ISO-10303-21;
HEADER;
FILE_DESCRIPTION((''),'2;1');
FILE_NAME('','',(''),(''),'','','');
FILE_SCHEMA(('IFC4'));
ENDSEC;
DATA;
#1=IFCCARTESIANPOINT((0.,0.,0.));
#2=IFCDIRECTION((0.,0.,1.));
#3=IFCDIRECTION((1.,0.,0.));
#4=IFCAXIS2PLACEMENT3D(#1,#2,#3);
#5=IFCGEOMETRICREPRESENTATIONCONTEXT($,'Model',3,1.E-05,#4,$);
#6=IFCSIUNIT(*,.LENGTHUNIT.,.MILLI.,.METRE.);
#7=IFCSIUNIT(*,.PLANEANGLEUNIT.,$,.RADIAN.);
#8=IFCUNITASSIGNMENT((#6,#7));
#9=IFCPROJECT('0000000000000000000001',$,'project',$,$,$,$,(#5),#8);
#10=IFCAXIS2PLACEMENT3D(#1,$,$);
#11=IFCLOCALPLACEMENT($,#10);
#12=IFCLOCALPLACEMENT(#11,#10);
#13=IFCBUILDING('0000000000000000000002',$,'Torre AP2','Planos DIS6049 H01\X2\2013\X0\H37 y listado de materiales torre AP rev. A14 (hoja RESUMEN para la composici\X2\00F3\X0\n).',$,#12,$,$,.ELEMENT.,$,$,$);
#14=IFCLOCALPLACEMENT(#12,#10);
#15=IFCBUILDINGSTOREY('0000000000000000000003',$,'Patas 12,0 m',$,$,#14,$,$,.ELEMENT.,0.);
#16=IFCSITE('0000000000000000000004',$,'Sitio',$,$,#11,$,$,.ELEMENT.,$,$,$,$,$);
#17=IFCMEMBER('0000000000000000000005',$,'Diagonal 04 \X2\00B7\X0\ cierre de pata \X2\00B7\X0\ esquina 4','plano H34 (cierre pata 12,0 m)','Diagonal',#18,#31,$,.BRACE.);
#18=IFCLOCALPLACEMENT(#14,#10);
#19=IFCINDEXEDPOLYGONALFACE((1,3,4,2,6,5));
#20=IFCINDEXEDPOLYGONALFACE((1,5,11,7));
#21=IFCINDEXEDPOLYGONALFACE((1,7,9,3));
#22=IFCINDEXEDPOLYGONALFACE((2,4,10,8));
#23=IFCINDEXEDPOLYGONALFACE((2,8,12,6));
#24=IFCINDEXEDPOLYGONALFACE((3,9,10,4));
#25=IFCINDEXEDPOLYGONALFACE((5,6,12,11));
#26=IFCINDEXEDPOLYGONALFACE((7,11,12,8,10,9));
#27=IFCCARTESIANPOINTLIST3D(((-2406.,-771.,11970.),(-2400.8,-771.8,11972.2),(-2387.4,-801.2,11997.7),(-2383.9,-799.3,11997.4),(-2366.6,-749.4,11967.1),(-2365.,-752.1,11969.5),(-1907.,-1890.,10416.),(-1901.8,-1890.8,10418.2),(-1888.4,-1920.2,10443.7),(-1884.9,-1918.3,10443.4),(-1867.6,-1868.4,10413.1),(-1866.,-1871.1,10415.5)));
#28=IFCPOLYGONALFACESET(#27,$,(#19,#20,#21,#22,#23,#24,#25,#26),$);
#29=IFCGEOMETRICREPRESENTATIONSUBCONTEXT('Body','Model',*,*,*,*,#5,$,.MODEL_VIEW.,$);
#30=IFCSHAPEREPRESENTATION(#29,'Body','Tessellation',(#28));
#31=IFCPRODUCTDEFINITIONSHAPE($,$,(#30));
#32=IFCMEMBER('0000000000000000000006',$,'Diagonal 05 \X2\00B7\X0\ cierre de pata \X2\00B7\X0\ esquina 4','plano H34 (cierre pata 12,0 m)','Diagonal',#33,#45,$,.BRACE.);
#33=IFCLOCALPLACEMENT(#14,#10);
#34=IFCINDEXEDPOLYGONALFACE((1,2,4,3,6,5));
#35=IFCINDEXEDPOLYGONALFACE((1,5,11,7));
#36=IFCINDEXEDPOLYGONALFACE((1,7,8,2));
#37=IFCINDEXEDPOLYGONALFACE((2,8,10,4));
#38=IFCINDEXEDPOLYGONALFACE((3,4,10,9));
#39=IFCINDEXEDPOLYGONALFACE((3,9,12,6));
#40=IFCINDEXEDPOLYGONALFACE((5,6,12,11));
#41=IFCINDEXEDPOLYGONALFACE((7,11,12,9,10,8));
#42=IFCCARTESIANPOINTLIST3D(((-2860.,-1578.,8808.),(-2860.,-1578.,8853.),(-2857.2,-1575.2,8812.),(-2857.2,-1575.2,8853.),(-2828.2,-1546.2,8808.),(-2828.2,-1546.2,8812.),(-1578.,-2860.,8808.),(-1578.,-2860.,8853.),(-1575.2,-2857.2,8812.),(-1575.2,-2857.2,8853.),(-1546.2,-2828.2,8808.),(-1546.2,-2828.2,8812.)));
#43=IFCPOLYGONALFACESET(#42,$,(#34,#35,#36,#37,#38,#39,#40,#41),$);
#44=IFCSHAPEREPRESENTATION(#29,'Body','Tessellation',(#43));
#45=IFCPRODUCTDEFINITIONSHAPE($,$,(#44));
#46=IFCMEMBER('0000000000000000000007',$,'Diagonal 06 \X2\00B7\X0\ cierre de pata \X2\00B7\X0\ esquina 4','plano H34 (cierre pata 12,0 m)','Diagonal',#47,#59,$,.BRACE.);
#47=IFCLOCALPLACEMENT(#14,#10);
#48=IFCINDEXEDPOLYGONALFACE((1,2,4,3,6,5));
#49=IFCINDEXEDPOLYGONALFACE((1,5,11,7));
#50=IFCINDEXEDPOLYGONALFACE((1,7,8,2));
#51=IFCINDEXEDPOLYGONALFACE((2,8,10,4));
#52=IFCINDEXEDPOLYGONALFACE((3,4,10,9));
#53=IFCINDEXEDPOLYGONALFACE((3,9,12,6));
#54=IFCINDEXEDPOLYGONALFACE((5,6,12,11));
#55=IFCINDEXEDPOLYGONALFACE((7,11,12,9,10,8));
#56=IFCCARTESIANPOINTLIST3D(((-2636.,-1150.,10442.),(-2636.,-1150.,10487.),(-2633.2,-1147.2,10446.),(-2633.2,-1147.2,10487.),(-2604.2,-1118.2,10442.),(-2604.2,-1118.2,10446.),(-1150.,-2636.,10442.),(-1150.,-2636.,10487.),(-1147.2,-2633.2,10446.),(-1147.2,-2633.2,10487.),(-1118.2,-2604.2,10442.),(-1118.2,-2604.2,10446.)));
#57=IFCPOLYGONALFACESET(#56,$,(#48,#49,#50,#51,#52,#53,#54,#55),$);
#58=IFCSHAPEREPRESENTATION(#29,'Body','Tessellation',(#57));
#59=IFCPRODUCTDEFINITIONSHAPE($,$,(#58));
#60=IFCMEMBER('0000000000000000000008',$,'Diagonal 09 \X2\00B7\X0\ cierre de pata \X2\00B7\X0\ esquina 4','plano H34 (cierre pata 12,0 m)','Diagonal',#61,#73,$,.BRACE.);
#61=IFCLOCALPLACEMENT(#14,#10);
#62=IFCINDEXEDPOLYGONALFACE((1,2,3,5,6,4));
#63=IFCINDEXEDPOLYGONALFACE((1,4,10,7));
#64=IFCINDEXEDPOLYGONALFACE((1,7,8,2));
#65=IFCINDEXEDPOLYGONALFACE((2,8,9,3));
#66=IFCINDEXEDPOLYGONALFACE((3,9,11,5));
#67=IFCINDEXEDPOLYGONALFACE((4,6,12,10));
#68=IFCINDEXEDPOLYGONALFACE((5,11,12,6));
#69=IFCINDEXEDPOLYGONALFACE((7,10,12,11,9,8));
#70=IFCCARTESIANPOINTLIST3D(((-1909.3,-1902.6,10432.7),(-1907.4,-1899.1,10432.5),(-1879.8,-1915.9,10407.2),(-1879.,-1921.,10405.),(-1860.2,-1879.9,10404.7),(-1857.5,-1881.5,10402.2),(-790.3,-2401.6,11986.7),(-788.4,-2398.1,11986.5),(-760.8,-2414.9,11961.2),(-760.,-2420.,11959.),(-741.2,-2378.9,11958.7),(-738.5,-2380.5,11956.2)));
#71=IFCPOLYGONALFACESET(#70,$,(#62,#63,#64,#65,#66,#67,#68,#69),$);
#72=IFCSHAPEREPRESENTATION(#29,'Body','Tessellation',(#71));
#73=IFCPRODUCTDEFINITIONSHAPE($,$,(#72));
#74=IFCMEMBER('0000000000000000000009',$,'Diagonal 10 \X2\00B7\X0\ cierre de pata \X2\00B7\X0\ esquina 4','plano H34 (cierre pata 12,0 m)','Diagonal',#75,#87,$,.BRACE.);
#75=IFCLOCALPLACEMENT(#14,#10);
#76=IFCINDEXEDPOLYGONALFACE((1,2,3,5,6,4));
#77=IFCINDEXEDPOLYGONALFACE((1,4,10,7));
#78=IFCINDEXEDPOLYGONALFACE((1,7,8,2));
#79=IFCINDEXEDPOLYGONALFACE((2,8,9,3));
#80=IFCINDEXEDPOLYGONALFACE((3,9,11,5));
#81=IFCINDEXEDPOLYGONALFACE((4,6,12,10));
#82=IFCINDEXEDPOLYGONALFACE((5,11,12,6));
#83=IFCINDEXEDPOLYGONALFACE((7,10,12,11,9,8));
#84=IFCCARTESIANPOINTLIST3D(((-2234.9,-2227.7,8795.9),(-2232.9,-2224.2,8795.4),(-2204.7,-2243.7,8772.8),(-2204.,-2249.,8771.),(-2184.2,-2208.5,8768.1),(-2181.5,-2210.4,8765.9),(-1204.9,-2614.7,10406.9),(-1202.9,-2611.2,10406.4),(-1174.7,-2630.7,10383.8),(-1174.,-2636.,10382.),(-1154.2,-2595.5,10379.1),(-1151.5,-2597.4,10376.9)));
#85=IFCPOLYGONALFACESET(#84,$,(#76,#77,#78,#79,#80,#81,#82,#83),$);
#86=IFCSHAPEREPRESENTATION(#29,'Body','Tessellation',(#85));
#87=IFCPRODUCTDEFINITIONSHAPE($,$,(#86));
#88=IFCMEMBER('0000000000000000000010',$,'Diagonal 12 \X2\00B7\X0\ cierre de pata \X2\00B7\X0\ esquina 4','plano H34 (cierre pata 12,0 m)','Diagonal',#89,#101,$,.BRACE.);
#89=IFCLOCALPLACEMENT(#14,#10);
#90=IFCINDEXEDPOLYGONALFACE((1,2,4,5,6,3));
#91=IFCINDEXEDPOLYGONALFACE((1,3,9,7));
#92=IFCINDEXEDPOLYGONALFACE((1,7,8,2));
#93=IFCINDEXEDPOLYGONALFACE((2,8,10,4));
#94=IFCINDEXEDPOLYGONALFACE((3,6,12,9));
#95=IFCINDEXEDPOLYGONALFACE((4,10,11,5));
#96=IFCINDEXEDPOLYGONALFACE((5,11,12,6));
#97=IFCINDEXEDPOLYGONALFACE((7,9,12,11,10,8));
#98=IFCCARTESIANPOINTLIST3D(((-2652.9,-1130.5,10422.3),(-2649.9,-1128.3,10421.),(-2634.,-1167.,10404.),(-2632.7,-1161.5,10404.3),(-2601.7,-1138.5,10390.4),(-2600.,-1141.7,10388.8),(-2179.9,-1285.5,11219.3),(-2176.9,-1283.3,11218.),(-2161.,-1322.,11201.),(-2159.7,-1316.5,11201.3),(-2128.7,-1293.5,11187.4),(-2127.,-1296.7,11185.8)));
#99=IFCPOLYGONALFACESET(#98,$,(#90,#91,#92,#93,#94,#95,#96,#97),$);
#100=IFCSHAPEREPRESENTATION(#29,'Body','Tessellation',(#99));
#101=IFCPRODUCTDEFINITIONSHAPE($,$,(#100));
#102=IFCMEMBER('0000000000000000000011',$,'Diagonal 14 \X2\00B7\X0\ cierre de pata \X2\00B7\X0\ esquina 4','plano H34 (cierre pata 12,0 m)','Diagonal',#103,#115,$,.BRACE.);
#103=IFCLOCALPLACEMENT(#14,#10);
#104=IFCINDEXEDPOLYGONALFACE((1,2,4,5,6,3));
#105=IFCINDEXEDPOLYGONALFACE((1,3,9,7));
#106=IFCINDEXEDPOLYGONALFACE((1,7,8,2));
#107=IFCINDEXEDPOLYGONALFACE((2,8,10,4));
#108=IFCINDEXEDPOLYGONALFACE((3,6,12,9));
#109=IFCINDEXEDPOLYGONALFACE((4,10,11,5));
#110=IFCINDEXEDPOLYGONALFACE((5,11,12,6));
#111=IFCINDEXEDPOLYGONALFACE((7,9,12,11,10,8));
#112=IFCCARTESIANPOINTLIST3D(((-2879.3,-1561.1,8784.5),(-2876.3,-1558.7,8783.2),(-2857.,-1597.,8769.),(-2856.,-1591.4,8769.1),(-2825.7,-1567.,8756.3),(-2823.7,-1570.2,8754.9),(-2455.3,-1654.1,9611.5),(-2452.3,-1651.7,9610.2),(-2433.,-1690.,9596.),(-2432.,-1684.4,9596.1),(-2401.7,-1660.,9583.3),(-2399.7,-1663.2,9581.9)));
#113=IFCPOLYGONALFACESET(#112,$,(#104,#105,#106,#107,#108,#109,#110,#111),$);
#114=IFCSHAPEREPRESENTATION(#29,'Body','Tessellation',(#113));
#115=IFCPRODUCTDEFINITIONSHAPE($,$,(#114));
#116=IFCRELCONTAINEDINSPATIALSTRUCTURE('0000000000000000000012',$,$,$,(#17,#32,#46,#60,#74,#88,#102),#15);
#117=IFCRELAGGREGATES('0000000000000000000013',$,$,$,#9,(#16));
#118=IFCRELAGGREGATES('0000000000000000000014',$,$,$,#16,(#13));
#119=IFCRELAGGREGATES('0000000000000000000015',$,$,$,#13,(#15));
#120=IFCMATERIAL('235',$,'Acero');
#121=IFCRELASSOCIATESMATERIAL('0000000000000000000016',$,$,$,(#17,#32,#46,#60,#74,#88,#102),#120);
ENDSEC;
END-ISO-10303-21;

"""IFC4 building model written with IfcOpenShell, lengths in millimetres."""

from ifc_helpers import new_model, si_unit, frame, frame_2d, origin, origin_with_axes, place, context, subcontext, project, spatial, l_section, extrude, material, element, save


model = new_model("IFC4")

# Units and contexts
model_context = context("Model", 3, precision=1e-05, world=origin_with_axes())
body_context = subcontext(model_context, "Body", "Model", "MODEL_VIEW")
ifc_project = project(units=[si_unit("LENGTHUNIT", "METRE", prefix="MILLI"), si_unit("PLANEANGLEUNIT", "RADIAN")], contexts=[model_context])

# Site, building, storey
site_placement = place(None, origin())
site = spatial("IfcSite", under=ifc_project, at=site_placement, Name="Sitio", CompositionType="ELEMENT")
building_placement = place(site_placement, origin())
building = spatial("IfcBuilding", under=site, at=building_placement, Name="Torre AP2", Description="Planos DIS6049 H01–H37 y listado de materiales torre AP rev. A14 (hoja RESUMEN para la composición).", CompositionType="ELEMENT")
storey_placement = place(building_placement, origin())
storey = spatial("IfcBuildingStorey", under=building, at=storey_placement, Name="Patas 12,0 m", CompositionType="ELEMENT", Elevation=0.0)

# Members
ifc_material_1 = material(Name="235", Category="Acero")
member_1_placement = place(storey_placement, frame((-2406.0, -771.0, 11970.0), z_axis=(0.252159, -0.565463, -0.785281), x_axis=(0.874778, 0.480163, -0.064857)))
element("IfcMember", 1, at=member_1_placement, inside=storey, material=ifc_material_1, Name="Diagonal 04 · cierre de pata · esquina 4", Description="plano H34 (cierre pata 12,0 m)", ObjectType="Diagonal", PredefinedType="BRACE", context=body_context, shape_type="SweptSolid", body=[
    extrude(l_section(Depth=45.0, Width=45.0, Thickness=4.0, at=frame_2d((22.5, 22.5))), None, (0.0, 0.0, 1.0), 1978.9),
])
member_2_placement = place(storey_placement, frame((-2860.0, -1578.0, 8808.0), z_axis=(0.707107, -0.707107, 0.0), x_axis=(0.707107, 0.707107, 0.0)))
element("IfcMember", 2, at=member_2_placement, inside=storey, material=ifc_material_1, Name="Diagonal 05 · cierre de pata · esquina 4", Description="plano H34 (cierre pata 12,0 m)", ObjectType="Diagonal", PredefinedType="BRACE", context=body_context, shape_type="SweptSolid", body=[
    extrude(l_section(Depth=45.0, Width=45.0, Thickness=4.0, at=frame_2d((22.5, 22.5))), None, (0.0, 0.0, 1.0), 1813.0),
])
member_3_placement = place(storey_placement, frame((-2636.0, -1150.0, 10442.0), z_axis=(0.707107, -0.707107, 0.0), x_axis=(0.707107, 0.707107, 0.0)))
element("IfcMember", 3, at=member_3_placement, inside=storey, material=ifc_material_1, Name="Diagonal 06 · cierre de pata · esquina 4", Description="plano H34 (cierre pata 12,0 m)", ObjectType="Diagonal", PredefinedType="BRACE", context=body_context, shape_type="SweptSolid", body=[
    extrude(l_section(Depth=45.0, Width=45.0, Thickness=4.0, at=frame_2d((22.5, 22.5))), None, (0.0, 0.0, 1.0), 2101.5),
])
member_4_placement = place(storey_placement, frame((-1879.0, -1921.0, 10405.0), z_axis=(0.565463, -0.252159, 0.785281), x_axis=(0.476669, 0.876918, -0.061654)))
element("IfcMember", 4, at=member_4_placement, inside=storey, material=ifc_material_1, Name="Diagonal 09 · cierre de pata · esquina 4", Description="plano H34 (cierre pata 12,0 m)", ObjectType="Diagonal", PredefinedType="BRACE", context=body_context, shape_type="SweptSolid", body=[
    extrude(l_section(Depth=45.0, Width=45.0, Thickness=4.0, at=frame_2d((22.5, 22.5))), None, (0.0, 0.0, 1.0), 1978.9),
])
member_5_placement = place(storey_placement, frame((-2204.0, -2249.0, 8771.0), z_axis=(0.527963, -0.198371, 0.825775), x_axis=(0.5011, 0.857806, -0.114315)))
element("IfcMember", 5, at=member_5_placement, inside=storey, material=ifc_material_1, Name="Diagonal 10 · cierre de pata · esquina 4", Description="plano H34 (cierre pata 12,0 m)", ObjectType="Diagonal", PredefinedType="BRACE", context=body_context, shape_type="SweptSolid", body=[
    extrude(l_section(Depth=45.0, Width=45.0, Thickness=4.0, at=frame_2d((22.5, 22.5))), None, (0.0, 0.0, 1.0), 1950.9),
])
member_6_placement = place(storey_placement, frame((-2634.0, -1167.0, 10404.0), z_axis=(0.503373, -0.164953, 0.848178), x_axis=(0.754706, 0.561924, -0.338617)))
element("IfcMember", 6, at=member_6_placement, inside=storey, material=ifc_material_1, Name="Diagonal 12 · cierre de pata · esquina 4", Description="plano H34 (cierre pata 12,0 m)", ObjectType="Diagonal", PredefinedType="BRACE", context=body_context, shape_type="SweptSolid", body=[
    extrude(l_section(Depth=45.0, Width=45.0, Thickness=4.0, at=frame_2d((22.5, 22.5))), None, (0.0, 0.0, 1.0), 939.7),
])
member_7_placement = place(storey_placement, frame((-2857.0, -1597.0, 8769.0), z_axis=(0.453962, -0.099572, 0.88544), x_axis=(0.740469, 0.594896, -0.312737)))
element("IfcMember", 7, at=member_7_placement, inside=storey, material=ifc_material_1, Name="Diagonal 14 · cierre de pata · esquina 4", Description="plano H34 (cierre pata 12,0 m)", ObjectType="Diagonal", PredefinedType="BRACE", context=body_context, shape_type="SweptSolid", body=[
    extrude(l_section(Depth=45.0, Width=45.0, Thickness=4.0, at=frame_2d((22.5, 22.5))), None, (0.0, 0.0, 1.0), 934.0),
])

save(model, "model.ifc")
